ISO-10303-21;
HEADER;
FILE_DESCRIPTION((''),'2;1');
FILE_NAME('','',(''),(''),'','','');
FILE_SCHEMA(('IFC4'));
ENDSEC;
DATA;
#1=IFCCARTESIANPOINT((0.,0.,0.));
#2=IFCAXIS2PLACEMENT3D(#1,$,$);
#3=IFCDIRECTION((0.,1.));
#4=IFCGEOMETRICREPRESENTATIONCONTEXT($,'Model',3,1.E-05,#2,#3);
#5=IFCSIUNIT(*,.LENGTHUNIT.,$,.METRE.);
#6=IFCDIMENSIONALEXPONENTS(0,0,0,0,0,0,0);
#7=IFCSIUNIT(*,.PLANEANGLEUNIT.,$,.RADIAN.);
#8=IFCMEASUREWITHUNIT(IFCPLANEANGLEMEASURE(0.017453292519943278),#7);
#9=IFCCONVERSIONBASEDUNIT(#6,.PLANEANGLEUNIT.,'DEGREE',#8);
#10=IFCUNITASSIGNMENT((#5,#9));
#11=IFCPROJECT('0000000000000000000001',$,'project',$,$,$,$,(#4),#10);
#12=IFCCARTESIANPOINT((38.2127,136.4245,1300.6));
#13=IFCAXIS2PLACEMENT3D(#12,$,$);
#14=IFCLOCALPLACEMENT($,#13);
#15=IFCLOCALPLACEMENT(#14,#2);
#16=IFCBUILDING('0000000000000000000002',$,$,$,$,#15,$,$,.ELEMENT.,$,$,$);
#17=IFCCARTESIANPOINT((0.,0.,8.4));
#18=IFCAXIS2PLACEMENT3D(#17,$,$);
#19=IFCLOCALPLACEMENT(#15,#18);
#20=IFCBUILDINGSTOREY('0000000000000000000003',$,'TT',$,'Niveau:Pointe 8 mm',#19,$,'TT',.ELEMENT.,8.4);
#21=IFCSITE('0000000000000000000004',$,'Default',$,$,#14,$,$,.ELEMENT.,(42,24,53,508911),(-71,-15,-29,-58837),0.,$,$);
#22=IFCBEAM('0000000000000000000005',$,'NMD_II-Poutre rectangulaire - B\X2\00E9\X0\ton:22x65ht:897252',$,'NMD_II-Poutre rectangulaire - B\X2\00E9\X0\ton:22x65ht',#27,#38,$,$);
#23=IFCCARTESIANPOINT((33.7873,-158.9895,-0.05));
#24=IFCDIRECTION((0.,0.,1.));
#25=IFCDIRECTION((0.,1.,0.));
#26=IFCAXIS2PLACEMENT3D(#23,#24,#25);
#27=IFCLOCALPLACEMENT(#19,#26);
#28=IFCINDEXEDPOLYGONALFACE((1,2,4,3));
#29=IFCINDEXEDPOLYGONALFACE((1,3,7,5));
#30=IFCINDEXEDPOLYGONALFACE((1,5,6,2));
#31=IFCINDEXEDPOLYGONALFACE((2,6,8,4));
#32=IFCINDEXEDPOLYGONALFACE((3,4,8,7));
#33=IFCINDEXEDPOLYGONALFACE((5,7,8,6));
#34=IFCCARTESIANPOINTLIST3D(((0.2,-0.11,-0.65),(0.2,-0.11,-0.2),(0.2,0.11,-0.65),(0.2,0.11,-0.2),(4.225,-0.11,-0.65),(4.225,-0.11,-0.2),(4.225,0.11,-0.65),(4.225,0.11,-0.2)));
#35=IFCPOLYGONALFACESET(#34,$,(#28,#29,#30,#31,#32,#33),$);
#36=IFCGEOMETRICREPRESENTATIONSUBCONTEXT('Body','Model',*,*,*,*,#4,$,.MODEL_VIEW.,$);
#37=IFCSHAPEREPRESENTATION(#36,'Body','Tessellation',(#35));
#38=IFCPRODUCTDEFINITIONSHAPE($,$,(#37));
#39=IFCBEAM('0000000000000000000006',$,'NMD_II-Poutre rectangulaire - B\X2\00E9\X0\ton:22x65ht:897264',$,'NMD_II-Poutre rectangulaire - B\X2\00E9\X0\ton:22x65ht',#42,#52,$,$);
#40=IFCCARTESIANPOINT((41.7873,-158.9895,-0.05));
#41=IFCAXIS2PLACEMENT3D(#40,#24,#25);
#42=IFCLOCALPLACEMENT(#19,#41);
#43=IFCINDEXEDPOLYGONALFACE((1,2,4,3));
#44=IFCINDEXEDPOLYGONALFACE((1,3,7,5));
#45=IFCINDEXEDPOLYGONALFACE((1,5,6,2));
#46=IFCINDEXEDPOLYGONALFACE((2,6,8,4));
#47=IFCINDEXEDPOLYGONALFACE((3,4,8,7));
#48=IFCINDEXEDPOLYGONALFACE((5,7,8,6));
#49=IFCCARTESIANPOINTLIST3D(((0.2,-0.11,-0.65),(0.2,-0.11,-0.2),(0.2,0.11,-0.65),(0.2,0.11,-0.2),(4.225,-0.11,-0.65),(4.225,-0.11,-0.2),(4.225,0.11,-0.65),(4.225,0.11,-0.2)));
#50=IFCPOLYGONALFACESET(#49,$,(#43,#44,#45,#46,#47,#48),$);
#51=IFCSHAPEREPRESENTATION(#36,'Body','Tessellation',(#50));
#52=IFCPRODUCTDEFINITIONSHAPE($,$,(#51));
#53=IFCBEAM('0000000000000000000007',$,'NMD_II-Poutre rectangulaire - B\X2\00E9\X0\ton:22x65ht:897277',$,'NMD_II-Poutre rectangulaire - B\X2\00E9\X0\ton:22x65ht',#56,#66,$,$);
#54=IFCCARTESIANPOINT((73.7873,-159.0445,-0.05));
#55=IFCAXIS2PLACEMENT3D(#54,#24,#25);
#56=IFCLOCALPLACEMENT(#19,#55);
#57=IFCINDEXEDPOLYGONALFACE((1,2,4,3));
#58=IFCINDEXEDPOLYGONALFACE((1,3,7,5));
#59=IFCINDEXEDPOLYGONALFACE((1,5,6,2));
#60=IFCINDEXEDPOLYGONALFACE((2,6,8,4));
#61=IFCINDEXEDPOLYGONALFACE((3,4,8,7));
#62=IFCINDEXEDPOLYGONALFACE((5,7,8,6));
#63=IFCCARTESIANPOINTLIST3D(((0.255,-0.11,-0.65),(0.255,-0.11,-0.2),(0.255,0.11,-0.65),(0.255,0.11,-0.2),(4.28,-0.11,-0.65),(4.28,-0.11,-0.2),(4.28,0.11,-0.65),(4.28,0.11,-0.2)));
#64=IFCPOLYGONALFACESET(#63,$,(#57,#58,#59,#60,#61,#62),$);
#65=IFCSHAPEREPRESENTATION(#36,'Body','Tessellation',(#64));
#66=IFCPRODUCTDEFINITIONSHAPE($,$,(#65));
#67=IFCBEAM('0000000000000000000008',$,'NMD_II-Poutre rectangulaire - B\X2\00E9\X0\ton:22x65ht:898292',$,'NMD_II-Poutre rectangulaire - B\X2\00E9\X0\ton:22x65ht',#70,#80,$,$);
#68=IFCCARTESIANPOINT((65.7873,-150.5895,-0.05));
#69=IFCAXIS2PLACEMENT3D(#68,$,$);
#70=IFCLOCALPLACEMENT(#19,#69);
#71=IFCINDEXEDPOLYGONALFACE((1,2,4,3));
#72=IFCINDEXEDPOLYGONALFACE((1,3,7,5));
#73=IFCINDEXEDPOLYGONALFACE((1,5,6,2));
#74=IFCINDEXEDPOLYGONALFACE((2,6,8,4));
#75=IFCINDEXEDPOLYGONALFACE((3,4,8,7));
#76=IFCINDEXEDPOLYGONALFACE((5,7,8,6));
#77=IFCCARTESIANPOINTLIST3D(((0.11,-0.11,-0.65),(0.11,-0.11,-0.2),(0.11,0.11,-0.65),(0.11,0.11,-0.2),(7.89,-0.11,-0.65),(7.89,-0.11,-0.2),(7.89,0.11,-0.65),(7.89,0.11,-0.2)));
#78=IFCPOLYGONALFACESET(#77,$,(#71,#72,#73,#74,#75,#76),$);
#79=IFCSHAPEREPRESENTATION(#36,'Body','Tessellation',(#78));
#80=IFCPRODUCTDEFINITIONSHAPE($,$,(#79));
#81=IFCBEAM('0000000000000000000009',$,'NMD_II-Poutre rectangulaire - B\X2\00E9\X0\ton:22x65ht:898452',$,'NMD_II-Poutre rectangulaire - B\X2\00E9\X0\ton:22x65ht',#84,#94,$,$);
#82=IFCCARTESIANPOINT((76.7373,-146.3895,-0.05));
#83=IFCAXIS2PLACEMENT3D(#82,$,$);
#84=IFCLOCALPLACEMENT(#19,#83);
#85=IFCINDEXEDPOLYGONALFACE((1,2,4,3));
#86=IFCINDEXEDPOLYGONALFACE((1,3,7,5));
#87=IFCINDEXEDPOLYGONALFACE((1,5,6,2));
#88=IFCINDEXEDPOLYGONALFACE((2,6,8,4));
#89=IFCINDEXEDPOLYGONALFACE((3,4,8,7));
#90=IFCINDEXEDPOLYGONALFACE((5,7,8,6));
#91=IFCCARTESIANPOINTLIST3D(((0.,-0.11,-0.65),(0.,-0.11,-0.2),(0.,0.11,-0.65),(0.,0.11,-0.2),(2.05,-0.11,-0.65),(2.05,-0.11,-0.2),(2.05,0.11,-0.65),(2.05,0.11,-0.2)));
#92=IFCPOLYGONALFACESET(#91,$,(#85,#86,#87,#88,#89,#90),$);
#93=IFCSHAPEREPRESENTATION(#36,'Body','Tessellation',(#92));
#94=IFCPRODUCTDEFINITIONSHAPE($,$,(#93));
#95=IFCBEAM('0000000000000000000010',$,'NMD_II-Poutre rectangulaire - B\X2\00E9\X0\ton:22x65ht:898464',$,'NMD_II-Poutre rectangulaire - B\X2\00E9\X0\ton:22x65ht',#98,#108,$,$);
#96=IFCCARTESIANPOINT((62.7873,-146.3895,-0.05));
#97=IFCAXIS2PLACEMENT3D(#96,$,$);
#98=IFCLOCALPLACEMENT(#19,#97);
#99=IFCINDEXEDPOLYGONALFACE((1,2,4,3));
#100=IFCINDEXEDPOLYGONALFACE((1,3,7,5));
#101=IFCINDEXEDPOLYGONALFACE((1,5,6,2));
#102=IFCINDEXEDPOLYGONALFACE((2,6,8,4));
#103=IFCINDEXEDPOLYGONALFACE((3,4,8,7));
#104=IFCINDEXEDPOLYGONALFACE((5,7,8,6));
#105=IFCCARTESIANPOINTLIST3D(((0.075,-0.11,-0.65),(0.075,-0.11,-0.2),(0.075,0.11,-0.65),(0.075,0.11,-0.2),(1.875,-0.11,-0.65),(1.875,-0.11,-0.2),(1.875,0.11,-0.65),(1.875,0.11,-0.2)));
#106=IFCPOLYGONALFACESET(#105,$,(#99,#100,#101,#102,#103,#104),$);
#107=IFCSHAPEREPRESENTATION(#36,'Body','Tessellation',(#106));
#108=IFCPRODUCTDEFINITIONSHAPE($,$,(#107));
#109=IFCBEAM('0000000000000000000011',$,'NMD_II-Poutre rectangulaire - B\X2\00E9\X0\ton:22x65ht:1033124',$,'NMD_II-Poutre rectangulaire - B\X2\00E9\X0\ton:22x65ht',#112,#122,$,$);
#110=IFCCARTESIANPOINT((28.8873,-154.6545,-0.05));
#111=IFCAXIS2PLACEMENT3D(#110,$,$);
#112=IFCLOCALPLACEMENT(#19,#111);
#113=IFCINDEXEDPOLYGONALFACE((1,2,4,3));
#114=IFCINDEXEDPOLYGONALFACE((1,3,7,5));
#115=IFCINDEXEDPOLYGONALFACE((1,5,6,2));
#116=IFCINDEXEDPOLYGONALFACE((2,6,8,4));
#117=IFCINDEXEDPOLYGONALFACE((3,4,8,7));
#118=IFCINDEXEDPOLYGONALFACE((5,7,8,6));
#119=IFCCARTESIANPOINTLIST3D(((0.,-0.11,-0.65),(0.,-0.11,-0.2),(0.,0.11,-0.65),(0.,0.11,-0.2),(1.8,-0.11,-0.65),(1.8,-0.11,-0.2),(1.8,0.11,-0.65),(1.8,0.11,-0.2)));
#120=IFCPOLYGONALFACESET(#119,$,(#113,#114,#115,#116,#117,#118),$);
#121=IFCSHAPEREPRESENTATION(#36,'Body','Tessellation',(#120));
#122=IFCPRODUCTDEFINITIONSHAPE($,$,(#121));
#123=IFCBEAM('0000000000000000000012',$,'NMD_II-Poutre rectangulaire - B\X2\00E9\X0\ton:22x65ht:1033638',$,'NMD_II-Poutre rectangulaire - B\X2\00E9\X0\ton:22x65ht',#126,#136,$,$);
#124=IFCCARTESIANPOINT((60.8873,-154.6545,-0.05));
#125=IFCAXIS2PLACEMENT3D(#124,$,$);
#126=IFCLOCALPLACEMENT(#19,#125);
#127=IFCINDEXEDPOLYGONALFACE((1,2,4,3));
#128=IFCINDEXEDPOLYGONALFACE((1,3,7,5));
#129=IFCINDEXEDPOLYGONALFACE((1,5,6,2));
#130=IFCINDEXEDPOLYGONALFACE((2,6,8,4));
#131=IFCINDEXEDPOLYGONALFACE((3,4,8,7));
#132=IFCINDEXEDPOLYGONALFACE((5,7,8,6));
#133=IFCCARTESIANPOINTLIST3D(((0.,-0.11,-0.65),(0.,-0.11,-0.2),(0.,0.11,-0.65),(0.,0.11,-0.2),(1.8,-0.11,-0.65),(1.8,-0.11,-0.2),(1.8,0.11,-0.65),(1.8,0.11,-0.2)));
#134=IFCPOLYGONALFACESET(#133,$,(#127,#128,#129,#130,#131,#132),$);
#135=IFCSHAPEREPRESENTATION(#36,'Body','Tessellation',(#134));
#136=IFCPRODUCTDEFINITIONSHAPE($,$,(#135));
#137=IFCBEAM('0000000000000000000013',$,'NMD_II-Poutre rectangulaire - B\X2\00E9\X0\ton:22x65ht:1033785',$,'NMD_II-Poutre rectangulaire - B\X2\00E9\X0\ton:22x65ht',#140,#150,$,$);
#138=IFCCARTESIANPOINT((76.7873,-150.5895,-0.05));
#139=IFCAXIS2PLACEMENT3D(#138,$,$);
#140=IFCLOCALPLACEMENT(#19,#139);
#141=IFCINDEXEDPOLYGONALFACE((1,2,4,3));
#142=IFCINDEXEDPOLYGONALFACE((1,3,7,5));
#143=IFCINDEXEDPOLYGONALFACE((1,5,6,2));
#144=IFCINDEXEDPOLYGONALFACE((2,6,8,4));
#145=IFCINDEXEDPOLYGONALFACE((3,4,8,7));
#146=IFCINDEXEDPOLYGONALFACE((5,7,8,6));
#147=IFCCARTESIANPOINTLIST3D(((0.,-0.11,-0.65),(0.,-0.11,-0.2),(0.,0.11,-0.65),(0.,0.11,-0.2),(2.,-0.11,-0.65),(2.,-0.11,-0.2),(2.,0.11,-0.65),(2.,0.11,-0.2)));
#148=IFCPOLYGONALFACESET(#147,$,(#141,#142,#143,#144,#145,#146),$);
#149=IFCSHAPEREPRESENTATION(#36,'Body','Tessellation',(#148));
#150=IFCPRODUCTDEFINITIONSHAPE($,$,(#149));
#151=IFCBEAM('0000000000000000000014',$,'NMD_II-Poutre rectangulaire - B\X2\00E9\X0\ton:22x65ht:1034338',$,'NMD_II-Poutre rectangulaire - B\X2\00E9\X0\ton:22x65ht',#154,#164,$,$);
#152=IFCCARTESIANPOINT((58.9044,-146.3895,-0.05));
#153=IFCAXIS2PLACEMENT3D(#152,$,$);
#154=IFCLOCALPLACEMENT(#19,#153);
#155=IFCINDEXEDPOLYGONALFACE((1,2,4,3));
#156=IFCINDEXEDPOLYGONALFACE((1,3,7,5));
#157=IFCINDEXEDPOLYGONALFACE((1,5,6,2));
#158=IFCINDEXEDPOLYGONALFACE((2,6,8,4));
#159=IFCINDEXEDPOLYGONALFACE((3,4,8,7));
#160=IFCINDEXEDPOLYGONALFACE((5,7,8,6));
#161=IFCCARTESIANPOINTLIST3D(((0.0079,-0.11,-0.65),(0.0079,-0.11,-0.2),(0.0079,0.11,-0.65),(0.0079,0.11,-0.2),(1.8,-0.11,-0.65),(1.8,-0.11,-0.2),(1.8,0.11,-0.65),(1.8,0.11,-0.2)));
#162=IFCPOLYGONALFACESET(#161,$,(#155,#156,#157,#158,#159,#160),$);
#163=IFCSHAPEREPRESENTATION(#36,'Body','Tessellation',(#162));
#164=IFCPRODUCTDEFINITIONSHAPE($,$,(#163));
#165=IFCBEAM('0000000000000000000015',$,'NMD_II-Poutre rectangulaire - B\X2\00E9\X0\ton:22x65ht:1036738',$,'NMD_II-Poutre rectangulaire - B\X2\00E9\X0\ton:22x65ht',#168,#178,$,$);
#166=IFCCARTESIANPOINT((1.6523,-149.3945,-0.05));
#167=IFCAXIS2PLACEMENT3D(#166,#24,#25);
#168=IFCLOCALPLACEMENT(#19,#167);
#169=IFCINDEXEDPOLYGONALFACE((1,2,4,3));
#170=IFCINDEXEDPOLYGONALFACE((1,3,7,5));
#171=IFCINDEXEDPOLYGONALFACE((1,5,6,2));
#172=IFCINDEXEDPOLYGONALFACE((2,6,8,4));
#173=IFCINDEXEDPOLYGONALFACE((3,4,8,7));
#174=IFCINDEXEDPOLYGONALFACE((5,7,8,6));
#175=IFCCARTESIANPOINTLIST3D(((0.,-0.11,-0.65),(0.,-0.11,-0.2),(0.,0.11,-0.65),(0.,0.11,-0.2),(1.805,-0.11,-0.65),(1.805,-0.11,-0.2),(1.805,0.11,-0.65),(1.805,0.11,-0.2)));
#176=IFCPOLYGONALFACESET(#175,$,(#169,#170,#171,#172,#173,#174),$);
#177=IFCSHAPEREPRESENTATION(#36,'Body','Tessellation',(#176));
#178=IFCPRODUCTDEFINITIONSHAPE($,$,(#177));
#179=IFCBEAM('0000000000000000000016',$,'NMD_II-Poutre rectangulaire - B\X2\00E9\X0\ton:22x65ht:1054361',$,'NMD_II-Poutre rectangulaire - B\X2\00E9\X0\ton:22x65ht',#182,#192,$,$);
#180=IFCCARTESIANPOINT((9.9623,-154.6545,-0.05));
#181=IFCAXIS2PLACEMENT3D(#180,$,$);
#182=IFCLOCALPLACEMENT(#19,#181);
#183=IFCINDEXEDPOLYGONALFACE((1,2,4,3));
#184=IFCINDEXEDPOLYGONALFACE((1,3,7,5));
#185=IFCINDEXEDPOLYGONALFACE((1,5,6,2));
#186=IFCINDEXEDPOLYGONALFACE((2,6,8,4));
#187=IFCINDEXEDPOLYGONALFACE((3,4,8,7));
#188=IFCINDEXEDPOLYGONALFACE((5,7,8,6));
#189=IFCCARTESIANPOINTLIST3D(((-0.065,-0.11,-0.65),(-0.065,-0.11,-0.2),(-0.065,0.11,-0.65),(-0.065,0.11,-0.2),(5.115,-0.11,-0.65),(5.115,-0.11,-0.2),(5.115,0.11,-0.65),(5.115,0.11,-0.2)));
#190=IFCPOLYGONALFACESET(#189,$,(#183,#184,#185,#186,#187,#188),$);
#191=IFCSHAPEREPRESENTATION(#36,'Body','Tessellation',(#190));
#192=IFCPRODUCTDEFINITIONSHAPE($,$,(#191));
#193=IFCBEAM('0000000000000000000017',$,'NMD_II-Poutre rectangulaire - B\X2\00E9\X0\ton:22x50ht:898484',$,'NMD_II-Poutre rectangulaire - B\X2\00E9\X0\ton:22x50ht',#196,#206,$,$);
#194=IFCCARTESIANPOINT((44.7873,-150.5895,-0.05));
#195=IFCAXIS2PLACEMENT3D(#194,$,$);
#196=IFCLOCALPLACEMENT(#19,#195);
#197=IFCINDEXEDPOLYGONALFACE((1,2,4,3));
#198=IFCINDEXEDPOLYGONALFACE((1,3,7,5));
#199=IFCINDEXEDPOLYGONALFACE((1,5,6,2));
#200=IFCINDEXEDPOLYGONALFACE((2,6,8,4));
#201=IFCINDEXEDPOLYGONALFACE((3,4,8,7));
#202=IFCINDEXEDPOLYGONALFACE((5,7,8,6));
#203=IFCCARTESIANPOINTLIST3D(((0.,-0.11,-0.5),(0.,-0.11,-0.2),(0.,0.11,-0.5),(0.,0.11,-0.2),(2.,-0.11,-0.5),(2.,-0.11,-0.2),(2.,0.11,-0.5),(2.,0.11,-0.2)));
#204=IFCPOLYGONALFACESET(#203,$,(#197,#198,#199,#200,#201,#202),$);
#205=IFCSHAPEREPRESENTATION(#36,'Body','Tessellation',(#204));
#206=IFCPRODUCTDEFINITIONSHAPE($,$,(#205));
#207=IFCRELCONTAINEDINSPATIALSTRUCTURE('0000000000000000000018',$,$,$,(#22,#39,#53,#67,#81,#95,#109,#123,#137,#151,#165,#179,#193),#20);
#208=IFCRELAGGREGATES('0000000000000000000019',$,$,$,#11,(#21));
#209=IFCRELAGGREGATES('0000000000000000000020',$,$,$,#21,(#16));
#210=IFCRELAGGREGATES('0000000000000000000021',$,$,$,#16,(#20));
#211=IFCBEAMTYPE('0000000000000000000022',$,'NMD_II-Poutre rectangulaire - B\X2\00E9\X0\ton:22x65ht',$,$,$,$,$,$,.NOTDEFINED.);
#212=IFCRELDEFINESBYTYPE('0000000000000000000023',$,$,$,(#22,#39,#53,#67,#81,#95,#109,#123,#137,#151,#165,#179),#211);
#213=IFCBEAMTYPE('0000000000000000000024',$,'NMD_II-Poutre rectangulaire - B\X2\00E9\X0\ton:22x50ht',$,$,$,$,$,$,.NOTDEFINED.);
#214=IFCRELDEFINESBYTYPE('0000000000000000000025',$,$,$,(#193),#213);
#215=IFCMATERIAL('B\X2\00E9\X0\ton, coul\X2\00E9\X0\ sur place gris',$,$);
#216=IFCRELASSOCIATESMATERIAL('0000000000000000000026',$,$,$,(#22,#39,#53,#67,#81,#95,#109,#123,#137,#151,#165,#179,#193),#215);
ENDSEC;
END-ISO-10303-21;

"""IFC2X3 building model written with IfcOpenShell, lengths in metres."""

from ifc_helpers import new_model, entity, si_unit, converted_unit, direction, frame, frame_2d, origin, place, context, subcontext, project, spatial, rectangle, extrude, material, type_object, element, save


model = new_model("IFC2X3")

# Units and contexts
model_context = context("Model", 3, precision=1e-05, world=origin(), true_north=direction((0.0, 1.0)))
body_context = subcontext(model_context, "Body", "Model", "MODEL_VIEW")
ifc_project = project(units=[si_unit("LENGTHUNIT", "METRE"), converted_unit("PLANEANGLEUNIT", "DEGREE", entity("IfcPlaneAngleMeasure", 0.017453292519943278), si_unit("PLANEANGLEUNIT", "RADIAN"), dimensions=[0, 0, 0, 0, 0, 0, 0])], contexts=[model_context])

# Site, building, storey
site_placement = place(None, frame((38.2127, 136.4245, 1300.6)))
site = spatial("IfcSite", under=ifc_project, at=site_placement, Name="Default", CompositionType="ELEMENT", RefLatitude=(42, 24, 53, 508911), RefLongitude=(-71, -15, -29, -58837), RefElevation=0.0)
building_placement = place(site_placement, origin())
building = spatial("IfcBuilding", under=site, at=building_placement, CompositionType="ELEMENT")
storey_placement = place(building_placement, frame((0.0, 0.0, 8.4)))
storey = spatial("IfcBuildingStorey", under=building, at=storey_placement, Name="TT", ObjectType="Niveau:Pointe 8 mm", LongName="TT", CompositionType="ELEMENT", Elevation=8.4)

# Beams
ifc_material_1 = material(Name="Béton, coulé sur place gris")
beam_type_1 = type_object("IfcBeamType", Name="NMD_II-Poutre rectangulaire - Béton:22x65ht", PredefinedType="NOTDEFINED")
beam_1_placement = place(storey_placement, frame((33.7873, -158.9895, -0.05), z_axis=(0.0, 0.0, 1.0), x_axis=(0.0, 1.0, 0.0)))
element("IfcBeam", 1, at=beam_1_placement, inside=storey, type_object=beam_type_1, material=ifc_material_1, Name="NMD_II-Poutre rectangulaire - Béton:22x65ht:897252", ObjectType="NMD_II-Poutre rectangulaire - Béton:22x65ht", context=body_context, shape_type="SweptSolid", body=[
    extrude(rectangle(XDim=0.45, YDim=0.22, at=frame_2d((0.0, 0.0), x_axis=(1.0, 0.0))), frame((0.2, 0.0, -0.425), z_axis=(1.0, 0.0, 0.0), x_axis=(0.0, 0.0, -1.0)), (0.0, 0.0, 1.0), 4.025),
])
beam_2_placement = place(storey_placement, frame((41.7873, -158.9895, -0.05), z_axis=(0.0, 0.0, 1.0), x_axis=(0.0, 1.0, 0.0)))
element("IfcBeam", 2, at=beam_2_placement, inside=storey, type_object=beam_type_1, material=ifc_material_1, Name="NMD_II-Poutre rectangulaire - Béton:22x65ht:897264", ObjectType="NMD_II-Poutre rectangulaire - Béton:22x65ht", context=body_context, shape_type="SweptSolid", body=[
    extrude(rectangle(XDim=0.45, YDim=0.22, at=frame_2d((0.0, 0.0), x_axis=(1.0, 0.0))), frame((0.2, 0.0, -0.425), z_axis=(1.0, 0.0, 0.0), x_axis=(0.0, 0.0, -1.0)), (0.0, 0.0, 1.0), 4.025),
])
beam_3_placement = place(storey_placement, frame((73.7873, -159.0445, -0.05), z_axis=(0.0, 0.0, 1.0), x_axis=(0.0, 1.0, 0.0)))
element("IfcBeam", 3, at=beam_3_placement, inside=storey, type_object=beam_type_1, material=ifc_material_1, Name="NMD_II-Poutre rectangulaire - Béton:22x65ht:897277", ObjectType="NMD_II-Poutre rectangulaire - Béton:22x65ht", context=body_context, shape_type="SweptSolid", body=[
    extrude(rectangle(XDim=0.45, YDim=0.22, at=frame_2d((0.0, 0.0), x_axis=(1.0, 0.0))), frame((0.255, 0.0, -0.425), z_axis=(1.0, 0.0, 0.0), x_axis=(0.0, 0.0, -1.0)), (0.0, 0.0, 1.0), 4.025),
])
beam_4_placement = place(storey_placement, frame((65.7873, -150.5895, -0.05)))
element("IfcBeam", 4, at=beam_4_placement, inside=storey, type_object=beam_type_1, material=ifc_material_1, Name="NMD_II-Poutre rectangulaire - Béton:22x65ht:898292", ObjectType="NMD_II-Poutre rectangulaire - Béton:22x65ht", context=body_context, shape_type="SweptSolid", body=[
    extrude(rectangle(XDim=0.45, YDim=0.22, at=frame_2d((0.0, 0.0), x_axis=(1.0, 0.0))), frame((0.11, 0.0, -0.425), z_axis=(1.0, 0.0, 0.0), x_axis=(0.0, 0.0, -1.0)), (0.0, 0.0, 1.0), 7.78),
])
beam_5_placement = place(storey_placement, frame((76.7373, -146.3895, -0.05)))
element("IfcBeam", 5, at=beam_5_placement, inside=storey, type_object=beam_type_1, material=ifc_material_1, Name="NMD_II-Poutre rectangulaire - Béton:22x65ht:898452", ObjectType="NMD_II-Poutre rectangulaire - Béton:22x65ht", context=body_context, shape_type="SweptSolid", body=[
    extrude(rectangle(XDim=0.45, YDim=0.22, at=frame_2d((0.0, 0.0), x_axis=(1.0, 0.0))), frame((0.0, 0.0, -0.425), z_axis=(1.0, 0.0, 0.0), x_axis=(0.0, 0.0, -1.0)), (0.0, 0.0, 1.0), 2.05),
])
beam_6_placement = place(storey_placement, frame((62.7873, -146.3895, -0.05)))
element("IfcBeam", 6, at=beam_6_placement, inside=storey, type_object=beam_type_1, material=ifc_material_1, Name="NMD_II-Poutre rectangulaire - Béton:22x65ht:898464", ObjectType="NMD_II-Poutre rectangulaire - Béton:22x65ht", context=body_context, shape_type="SweptSolid", body=[
    extrude(rectangle(XDim=0.45, YDim=0.22, at=frame_2d((0.0, 0.0), x_axis=(1.0, 0.0))), frame((0.075, 0.0, -0.425), z_axis=(1.0, 0.0, 0.0), x_axis=(0.0, 0.0, -1.0)), (0.0, 0.0, 1.0), 1.8),
])
for number, where, name in (
    (7, (28.8873, -154.6545, -0.05), "NMD_II-Poutre rectangulaire - Béton:22x65ht:1033124"),
    (8, (60.8873, -154.6545, -0.05), "NMD_II-Poutre rectangulaire - Béton:22x65ht:1033638"),
):
    element("IfcBeam", number, at=place(storey_placement, frame(where)), inside=storey, type_object=beam_type_1, material=ifc_material_1, Name=name, ObjectType="NMD_II-Poutre rectangulaire - Béton:22x65ht", context=body_context, shape_type="SweptSolid", body=[
        extrude(rectangle(XDim=0.45, YDim=0.22, at=frame_2d((0.0, 0.0), x_axis=(1.0, 0.0))), frame((0.0, 0.0, -0.425), z_axis=(1.0, 0.0, 0.0), x_axis=(0.0, 0.0, -1.0)), (0.0, 0.0, 1.0), 1.8),
    ])
beam_7_placement = place(storey_placement, frame((76.7873, -150.5895, -0.05)))
element("IfcBeam", 9, at=beam_7_placement, inside=storey, type_object=beam_type_1, material=ifc_material_1, Name="NMD_II-Poutre rectangulaire - Béton:22x65ht:1033785", ObjectType="NMD_II-Poutre rectangulaire - Béton:22x65ht", context=body_context, shape_type="SweptSolid", body=[
    extrude(rectangle(XDim=0.45, YDim=0.22, at=frame_2d((0.0, 0.0), x_axis=(1.0, 0.0))), frame((0.0, 0.0, -0.425), z_axis=(1.0, 0.0, 0.0), x_axis=(0.0, 0.0, -1.0)), (0.0, 0.0, 1.0), 2.0),
])
beam_8_placement = place(storey_placement, frame((58.9044, -146.3895, -0.05)))
element("IfcBeam", 10, at=beam_8_placement, inside=storey, type_object=beam_type_1, material=ifc_material_1, Name="NMD_II-Poutre rectangulaire - Béton:22x65ht:1034338", ObjectType="NMD_II-Poutre rectangulaire - Béton:22x65ht", context=body_context, shape_type="SweptSolid", body=[
    extrude(rectangle(XDim=0.45, YDim=0.22, at=frame_2d((0.0, 0.0), x_axis=(1.0, 0.0))), frame((0.0079, 0.0, -0.425), z_axis=(1.0, 0.0, 0.0), x_axis=(0.0, 0.0, -1.0)), (0.0, 0.0, 1.0), 1.7921),
])
beam_9_placement = place(storey_placement, frame((1.6523, -149.3945, -0.05), z_axis=(0.0, 0.0, 1.0), x_axis=(0.0, 1.0, 0.0)))
element("IfcBeam", 11, at=beam_9_placement, inside=storey, type_object=beam_type_1, material=ifc_material_1, Name="NMD_II-Poutre rectangulaire - Béton:22x65ht:1036738", ObjectType="NMD_II-Poutre rectangulaire - Béton:22x65ht", context=body_context, shape_type="SweptSolid", body=[
    extrude(rectangle(XDim=0.45, YDim=0.22, at=frame_2d((0.0, 0.0), x_axis=(1.0, 0.0))), frame((0.0, 0.0, -0.425), z_axis=(1.0, 0.0, 0.0), x_axis=(0.0, 0.0, -1.0)), (0.0, 0.0, 1.0), 1.805),
])
beam_10_placement = place(storey_placement, frame((9.9623, -154.6545, -0.05)))
element("IfcBeam", 12, at=beam_10_placement, inside=storey, type_object=beam_type_1, material=ifc_material_1, Name="NMD_II-Poutre rectangulaire - Béton:22x65ht:1054361", ObjectType="NMD_II-Poutre rectangulaire - Béton:22x65ht", context=body_context, shape_type="SweptSolid", body=[
    extrude(rectangle(XDim=0.45, YDim=0.22, at=frame_2d((0.0, 0.0), x_axis=(1.0, 0.0))), frame((-0.065, 0.0, -0.425), z_axis=(1.0, 0.0, 0.0), x_axis=(0.0, 0.0, -1.0)), (0.0, 0.0, 1.0), 5.18),
])
beam_type_2 = type_object("IfcBeamType", Name="NMD_II-Poutre rectangulaire - Béton:22x50ht", PredefinedType="NOTDEFINED")
beam_11_placement = place(storey_placement, frame((44.7873, -150.5895, -0.05)))
element("IfcBeam", 13, at=beam_11_placement, inside=storey, type_object=beam_type_2, material=ifc_material_1, Name="NMD_II-Poutre rectangulaire - Béton:22x50ht:898484", ObjectType="NMD_II-Poutre rectangulaire - Béton:22x50ht", context=body_context, shape_type="SweptSolid", body=[
    extrude(rectangle(XDim=0.3, YDim=0.22, at=frame_2d((0.0, 0.0), x_axis=(1.0, 0.0))), frame((0.0, 0.0, -0.35), z_axis=(1.0, 0.0, 0.0), x_axis=(0.0, 0.0, -1.0)), (0.0, 0.0, 1.0), 2.0),
])

save(model, "model.ifc")
